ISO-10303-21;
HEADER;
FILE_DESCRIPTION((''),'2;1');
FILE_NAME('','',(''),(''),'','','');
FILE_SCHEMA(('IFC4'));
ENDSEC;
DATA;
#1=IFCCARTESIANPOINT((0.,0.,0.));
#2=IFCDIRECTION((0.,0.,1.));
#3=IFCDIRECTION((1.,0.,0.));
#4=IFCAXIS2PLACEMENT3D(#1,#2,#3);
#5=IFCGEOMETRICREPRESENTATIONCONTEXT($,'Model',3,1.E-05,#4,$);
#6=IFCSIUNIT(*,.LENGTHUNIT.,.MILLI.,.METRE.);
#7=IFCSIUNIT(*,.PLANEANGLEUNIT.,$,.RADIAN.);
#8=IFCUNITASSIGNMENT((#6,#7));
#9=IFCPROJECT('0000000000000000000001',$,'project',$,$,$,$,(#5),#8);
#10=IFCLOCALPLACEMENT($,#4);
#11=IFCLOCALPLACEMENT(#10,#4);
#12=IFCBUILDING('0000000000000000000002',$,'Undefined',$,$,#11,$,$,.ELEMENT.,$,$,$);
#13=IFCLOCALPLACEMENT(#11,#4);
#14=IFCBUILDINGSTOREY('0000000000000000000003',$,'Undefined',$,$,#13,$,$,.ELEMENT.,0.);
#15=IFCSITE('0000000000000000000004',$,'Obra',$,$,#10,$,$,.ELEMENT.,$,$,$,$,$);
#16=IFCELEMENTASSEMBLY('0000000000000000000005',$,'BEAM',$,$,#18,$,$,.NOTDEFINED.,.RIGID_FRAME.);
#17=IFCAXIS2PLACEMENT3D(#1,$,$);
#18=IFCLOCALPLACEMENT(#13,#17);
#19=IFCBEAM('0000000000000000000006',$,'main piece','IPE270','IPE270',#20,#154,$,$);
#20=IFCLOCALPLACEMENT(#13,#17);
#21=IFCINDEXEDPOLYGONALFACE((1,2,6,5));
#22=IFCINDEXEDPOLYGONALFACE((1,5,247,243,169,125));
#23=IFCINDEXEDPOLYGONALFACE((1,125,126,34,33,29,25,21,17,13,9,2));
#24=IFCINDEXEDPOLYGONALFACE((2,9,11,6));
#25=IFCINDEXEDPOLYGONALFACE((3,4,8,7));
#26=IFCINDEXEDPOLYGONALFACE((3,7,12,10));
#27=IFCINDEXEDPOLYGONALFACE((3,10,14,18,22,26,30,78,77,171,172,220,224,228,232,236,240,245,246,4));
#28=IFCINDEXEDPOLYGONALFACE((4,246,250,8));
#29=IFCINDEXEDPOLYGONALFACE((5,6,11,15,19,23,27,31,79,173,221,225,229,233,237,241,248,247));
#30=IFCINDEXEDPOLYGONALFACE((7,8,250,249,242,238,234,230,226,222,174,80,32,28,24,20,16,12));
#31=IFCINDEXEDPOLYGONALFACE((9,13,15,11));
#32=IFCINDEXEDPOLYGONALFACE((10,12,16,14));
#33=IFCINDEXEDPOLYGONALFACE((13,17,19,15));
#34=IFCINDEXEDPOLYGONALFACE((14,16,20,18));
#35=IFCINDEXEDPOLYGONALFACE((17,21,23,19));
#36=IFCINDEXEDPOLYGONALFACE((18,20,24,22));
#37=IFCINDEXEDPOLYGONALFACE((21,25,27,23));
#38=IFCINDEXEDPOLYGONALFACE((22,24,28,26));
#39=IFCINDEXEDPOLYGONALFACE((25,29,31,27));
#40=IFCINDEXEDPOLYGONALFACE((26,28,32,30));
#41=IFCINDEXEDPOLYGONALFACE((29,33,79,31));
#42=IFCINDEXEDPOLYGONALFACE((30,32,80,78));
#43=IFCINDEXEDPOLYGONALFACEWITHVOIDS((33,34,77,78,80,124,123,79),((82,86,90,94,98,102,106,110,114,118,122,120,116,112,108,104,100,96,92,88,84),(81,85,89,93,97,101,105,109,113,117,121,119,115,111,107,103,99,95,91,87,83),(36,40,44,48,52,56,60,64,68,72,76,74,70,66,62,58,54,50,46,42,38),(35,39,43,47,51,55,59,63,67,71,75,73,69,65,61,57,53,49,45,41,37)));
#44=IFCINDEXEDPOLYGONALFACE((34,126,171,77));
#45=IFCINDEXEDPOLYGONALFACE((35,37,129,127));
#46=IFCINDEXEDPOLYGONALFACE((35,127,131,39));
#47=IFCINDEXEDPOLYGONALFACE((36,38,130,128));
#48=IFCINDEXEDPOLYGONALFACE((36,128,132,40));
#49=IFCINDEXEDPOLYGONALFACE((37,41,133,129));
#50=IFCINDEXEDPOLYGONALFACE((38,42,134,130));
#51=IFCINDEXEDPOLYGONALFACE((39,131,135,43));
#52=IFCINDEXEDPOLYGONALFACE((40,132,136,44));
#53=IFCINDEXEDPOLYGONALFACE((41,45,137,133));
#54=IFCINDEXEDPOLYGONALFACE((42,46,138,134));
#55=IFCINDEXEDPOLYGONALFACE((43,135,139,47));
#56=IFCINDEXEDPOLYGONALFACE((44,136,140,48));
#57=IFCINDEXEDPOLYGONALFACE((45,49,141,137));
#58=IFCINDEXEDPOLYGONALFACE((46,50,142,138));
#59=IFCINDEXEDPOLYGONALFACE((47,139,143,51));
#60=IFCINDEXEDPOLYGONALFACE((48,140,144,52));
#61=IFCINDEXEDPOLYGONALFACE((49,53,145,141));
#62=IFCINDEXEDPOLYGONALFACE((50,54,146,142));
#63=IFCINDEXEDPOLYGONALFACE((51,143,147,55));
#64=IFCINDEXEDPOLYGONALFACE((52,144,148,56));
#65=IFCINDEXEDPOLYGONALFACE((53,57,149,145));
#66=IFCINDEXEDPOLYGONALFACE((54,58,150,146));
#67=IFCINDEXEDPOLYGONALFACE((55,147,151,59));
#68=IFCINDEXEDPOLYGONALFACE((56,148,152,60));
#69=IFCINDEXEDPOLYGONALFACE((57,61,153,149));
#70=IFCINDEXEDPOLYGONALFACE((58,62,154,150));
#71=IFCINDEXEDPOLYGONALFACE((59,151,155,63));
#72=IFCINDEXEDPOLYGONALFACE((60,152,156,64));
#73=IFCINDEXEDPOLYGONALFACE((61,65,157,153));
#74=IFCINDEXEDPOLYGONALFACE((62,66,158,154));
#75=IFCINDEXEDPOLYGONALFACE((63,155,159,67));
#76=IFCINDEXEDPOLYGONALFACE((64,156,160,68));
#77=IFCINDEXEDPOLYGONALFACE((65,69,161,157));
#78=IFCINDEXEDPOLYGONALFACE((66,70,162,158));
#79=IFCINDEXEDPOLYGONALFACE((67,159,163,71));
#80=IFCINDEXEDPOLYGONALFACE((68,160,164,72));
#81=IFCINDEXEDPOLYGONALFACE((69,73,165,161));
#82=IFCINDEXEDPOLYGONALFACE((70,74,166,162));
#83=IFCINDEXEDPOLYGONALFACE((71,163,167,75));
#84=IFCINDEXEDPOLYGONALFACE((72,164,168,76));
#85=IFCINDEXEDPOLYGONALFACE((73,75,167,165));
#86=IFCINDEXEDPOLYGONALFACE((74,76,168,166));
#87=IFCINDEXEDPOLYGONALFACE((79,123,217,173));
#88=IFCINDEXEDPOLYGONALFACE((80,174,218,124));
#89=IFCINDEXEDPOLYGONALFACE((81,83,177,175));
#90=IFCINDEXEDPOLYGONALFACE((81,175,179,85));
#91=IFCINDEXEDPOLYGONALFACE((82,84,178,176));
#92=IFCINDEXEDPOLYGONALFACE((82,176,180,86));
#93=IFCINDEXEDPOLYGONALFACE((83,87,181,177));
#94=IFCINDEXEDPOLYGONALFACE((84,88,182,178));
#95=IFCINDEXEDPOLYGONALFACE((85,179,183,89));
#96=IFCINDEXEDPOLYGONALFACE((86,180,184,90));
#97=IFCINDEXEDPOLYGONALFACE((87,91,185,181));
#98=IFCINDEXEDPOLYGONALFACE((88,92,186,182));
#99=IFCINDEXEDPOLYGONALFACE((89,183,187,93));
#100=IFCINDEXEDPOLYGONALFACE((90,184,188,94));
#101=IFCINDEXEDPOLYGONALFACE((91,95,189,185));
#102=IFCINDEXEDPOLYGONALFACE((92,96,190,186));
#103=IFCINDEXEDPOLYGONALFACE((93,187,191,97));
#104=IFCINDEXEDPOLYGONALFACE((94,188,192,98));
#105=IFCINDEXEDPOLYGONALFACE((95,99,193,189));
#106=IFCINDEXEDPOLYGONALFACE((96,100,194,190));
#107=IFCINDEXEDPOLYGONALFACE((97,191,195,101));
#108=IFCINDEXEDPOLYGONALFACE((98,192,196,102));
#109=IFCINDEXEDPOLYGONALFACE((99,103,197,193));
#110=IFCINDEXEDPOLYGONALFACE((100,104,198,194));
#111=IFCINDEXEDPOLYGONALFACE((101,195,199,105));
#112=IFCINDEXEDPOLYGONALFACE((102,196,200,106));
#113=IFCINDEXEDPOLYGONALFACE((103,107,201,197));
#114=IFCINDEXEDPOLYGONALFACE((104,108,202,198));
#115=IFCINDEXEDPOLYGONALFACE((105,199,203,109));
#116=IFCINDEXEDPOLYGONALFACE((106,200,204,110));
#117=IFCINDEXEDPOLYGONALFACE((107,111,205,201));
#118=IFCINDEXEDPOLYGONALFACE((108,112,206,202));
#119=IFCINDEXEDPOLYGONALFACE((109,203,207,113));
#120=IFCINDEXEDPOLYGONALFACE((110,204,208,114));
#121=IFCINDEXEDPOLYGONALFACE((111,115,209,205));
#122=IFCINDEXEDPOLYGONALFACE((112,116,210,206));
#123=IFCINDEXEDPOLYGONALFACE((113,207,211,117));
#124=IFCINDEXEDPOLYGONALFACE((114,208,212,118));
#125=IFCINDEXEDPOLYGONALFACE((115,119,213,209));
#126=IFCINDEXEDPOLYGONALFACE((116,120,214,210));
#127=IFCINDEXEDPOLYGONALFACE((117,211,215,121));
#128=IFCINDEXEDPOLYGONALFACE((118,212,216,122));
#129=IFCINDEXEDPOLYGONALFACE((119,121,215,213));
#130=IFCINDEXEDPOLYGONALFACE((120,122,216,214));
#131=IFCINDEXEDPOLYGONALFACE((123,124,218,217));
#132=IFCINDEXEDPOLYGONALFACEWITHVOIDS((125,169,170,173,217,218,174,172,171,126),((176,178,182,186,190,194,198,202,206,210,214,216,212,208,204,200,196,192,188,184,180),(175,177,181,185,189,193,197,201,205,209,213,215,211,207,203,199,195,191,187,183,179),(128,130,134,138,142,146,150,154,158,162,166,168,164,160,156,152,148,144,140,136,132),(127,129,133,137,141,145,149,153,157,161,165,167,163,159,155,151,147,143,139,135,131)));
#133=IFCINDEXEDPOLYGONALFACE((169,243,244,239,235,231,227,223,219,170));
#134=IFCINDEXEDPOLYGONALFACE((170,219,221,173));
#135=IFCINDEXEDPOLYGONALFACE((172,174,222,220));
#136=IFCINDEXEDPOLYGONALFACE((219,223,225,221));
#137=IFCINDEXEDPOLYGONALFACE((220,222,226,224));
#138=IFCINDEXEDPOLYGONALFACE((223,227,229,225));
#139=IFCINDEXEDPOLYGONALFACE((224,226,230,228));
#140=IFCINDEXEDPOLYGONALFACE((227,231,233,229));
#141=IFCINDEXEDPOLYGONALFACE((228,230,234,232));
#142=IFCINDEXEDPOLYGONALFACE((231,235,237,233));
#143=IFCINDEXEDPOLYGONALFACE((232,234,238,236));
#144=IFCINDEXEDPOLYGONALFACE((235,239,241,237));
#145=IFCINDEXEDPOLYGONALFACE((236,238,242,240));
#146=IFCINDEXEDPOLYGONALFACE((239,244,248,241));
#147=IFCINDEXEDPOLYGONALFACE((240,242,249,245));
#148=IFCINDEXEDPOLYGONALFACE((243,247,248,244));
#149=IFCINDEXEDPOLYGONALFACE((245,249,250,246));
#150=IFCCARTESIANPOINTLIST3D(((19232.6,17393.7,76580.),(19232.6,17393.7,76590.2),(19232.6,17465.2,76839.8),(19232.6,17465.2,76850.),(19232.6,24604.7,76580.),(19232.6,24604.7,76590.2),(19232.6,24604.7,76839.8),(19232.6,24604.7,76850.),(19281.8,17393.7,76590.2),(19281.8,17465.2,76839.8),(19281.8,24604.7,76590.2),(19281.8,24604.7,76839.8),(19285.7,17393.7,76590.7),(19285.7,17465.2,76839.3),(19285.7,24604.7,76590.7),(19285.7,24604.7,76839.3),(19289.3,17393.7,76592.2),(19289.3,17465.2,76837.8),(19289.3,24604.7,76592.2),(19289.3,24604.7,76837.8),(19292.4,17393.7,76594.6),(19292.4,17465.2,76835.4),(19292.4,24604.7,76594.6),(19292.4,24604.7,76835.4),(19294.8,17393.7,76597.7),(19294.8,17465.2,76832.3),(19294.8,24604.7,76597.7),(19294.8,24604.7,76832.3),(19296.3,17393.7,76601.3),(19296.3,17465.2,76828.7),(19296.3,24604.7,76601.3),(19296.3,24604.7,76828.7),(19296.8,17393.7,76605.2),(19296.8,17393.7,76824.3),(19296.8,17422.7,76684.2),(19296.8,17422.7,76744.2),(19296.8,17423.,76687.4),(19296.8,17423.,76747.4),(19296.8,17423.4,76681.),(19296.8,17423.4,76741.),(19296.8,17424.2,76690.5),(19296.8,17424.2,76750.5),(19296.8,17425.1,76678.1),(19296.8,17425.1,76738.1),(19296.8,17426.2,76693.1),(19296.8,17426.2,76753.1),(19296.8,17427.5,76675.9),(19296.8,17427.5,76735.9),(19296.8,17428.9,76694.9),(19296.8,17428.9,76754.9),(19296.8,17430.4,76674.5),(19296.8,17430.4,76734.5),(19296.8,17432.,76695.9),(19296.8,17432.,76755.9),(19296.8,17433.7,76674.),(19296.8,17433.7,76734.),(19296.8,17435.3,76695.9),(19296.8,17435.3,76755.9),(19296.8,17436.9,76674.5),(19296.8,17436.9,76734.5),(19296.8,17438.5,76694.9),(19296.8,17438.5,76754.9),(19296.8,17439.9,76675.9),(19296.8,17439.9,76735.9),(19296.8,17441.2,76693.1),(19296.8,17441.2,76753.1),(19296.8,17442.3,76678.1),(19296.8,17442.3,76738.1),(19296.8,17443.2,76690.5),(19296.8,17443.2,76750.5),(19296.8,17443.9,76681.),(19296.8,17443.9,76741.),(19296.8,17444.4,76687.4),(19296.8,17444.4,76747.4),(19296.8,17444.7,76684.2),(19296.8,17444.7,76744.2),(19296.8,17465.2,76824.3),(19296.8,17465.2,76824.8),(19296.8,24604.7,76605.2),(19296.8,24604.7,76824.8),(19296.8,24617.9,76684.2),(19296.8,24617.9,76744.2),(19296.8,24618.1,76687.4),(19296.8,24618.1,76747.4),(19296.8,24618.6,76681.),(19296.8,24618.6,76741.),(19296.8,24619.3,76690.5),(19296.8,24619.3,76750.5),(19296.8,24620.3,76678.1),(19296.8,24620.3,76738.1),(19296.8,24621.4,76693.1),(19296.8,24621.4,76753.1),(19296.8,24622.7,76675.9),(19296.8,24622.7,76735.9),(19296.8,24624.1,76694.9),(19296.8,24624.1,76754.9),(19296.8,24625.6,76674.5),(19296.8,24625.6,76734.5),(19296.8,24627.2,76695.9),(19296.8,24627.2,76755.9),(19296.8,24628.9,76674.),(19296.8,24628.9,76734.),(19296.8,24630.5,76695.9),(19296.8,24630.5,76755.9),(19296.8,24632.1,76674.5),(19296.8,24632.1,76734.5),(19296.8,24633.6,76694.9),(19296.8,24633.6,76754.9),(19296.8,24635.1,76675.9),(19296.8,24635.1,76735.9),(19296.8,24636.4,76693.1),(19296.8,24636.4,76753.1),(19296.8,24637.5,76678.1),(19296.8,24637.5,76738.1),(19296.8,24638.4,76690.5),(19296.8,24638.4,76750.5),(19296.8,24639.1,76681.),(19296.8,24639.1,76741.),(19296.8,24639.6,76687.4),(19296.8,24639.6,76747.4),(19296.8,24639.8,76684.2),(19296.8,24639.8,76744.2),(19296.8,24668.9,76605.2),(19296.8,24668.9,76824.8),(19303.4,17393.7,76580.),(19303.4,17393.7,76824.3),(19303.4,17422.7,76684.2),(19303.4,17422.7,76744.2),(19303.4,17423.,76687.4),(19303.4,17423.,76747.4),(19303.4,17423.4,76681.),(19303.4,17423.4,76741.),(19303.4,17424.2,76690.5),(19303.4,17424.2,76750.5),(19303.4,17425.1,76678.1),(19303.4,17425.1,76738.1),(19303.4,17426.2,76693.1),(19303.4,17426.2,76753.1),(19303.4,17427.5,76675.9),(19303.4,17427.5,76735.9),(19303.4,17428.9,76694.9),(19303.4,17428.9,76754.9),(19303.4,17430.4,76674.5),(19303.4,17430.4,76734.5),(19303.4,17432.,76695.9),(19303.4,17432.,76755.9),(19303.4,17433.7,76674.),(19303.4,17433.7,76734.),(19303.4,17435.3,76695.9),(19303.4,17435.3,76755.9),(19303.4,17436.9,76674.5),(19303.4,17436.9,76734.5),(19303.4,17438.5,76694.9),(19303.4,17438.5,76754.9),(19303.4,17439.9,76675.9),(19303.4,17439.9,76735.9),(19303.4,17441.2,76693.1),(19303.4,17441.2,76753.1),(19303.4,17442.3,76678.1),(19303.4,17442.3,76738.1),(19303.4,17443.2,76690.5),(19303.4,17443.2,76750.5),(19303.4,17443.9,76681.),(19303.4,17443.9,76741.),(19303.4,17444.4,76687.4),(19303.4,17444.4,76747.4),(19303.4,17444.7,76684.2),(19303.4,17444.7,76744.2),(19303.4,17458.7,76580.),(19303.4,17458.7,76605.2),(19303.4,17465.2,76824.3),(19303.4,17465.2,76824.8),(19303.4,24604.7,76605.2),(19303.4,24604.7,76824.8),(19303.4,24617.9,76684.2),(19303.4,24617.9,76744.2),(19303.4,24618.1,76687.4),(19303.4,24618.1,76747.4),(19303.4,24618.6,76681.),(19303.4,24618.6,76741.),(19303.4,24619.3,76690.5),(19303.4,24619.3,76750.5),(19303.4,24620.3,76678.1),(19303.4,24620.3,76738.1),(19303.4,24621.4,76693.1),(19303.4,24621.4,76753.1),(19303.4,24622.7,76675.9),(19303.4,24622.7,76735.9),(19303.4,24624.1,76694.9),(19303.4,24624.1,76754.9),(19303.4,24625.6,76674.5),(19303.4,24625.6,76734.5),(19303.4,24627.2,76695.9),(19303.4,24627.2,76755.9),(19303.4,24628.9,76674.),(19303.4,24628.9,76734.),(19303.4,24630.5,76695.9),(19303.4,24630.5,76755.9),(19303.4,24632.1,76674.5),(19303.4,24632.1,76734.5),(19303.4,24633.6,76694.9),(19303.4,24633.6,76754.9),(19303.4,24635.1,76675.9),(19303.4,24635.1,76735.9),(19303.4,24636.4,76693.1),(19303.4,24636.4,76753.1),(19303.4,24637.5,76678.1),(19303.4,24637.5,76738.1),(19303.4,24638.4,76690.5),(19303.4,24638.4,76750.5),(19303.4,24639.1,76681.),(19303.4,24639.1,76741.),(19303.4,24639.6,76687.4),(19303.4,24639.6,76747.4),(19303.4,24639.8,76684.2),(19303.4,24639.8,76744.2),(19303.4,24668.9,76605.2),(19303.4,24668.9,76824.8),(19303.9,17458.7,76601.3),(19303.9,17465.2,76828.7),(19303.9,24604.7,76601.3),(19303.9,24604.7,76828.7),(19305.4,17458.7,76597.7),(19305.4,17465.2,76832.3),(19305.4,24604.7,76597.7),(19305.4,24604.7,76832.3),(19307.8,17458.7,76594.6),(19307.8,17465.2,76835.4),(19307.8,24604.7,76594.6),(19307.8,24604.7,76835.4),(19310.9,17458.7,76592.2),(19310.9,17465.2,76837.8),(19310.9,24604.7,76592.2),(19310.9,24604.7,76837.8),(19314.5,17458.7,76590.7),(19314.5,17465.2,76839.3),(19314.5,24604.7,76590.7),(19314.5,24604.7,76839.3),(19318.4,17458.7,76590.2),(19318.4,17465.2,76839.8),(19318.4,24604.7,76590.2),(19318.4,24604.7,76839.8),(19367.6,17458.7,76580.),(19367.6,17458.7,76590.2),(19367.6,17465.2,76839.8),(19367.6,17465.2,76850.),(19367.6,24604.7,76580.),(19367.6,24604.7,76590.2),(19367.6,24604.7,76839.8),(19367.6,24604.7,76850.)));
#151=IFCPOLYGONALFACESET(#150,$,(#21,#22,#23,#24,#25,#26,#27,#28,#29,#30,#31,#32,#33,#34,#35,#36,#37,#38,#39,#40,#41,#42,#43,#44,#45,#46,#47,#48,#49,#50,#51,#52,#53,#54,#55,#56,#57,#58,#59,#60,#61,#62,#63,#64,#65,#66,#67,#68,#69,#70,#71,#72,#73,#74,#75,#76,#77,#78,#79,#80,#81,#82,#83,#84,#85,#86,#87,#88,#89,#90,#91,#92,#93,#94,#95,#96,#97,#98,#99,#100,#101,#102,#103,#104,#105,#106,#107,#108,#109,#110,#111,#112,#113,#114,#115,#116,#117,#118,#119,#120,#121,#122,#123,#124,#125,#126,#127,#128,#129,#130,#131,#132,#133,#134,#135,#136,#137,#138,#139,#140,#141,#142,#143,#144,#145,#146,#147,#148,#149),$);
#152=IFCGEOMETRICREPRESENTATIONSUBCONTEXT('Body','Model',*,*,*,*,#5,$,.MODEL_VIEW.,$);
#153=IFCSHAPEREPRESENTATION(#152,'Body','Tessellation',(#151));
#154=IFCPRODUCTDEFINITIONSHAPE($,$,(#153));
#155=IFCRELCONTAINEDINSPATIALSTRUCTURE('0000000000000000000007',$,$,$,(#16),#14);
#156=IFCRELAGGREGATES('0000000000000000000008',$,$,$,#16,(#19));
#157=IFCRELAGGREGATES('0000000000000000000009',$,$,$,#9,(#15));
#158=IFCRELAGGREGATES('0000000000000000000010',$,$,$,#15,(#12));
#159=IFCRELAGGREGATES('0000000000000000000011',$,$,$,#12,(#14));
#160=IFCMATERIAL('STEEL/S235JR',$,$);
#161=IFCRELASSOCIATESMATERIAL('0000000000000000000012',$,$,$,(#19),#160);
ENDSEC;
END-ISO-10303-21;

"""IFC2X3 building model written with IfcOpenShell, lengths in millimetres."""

from ifc_helpers import new_model, si_unit, frame, origin_with_axes, origin_2d_with_axis, place, context, subcontext, project, spatial, rectangle, circle, i_section, extrude, clip, halfspace, source, transform, mapped, material, element, aggregate, save


model = new_model("IFC2X3")

# Units and contexts
model_context = context("Model", 3, precision=1e-05, world=origin_with_axes())
body_context = subcontext(model_context, "Body", "Model", "MODEL_VIEW")
ifc_project = project(units=[si_unit("LENGTHUNIT", "METRE", prefix="MILLI"), si_unit("PLANEANGLEUNIT", "RADIAN")], contexts=[model_context])

# Site, building, storey
site_placement = place(None, origin_with_axes())
site = spatial("IfcSite", under=ifc_project, at=site_placement, Name="Obra", CompositionType="ELEMENT")
building_placement = place(site_placement, origin_with_axes())
building = spatial("IfcBuilding", under=site, at=building_placement, Name="Undefined", CompositionType="ELEMENT")
storey_placement = place(building_placement, origin_with_axes())
storey = spatial("IfcBuildingStorey", under=building, at=storey_placement, Name="Undefined", CompositionType="ELEMENT", Elevation=0.0)

# Shared definitions
ifc_material = material(Name="STEEL/S235JR")

# Element assembly, beam, openings
assembly_1_placement = place(storey_placement, origin_with_axes())
assembly_1 = element("IfcElementAssembly", 1, at=assembly_1_placement, inside=storey, Name="BEAM", AssemblyPlace="NOTDEFINED", PredefinedType="RIGID_FRAME")
beam_1_placement = place(assembly_1_placement, frame((19300.1, 17475.1, 76715.0), z_axis=(0.0, 0.0, 1.0), x_axis=(0.0, 1.0, 0.0)))
beam_1 = element("IfcBeam", 2, at=beam_1_placement, material=ifc_material, Name="main piece", Description="IPE270", ObjectType="IPE270", context=body_context, shape_type="Clipping", body=[
    clip(clip(extrude(i_section(OverallWidth=135.0, OverallDepth=270.0, WebThickness=6.6, FlangeThickness=10.2, FilletRadius=15.0, at=origin_2d_with_axis()), frame((7193.7, 0.0, 0.0), z_axis=(-1.0, 0.0, 0.0), x_axis=(0.0, -1.0, 0.0)), (0.0, 0.0, 1.0), 7275.2), halfspace(frame((7193.7, 0.0, -235.0), z_axis=(-1.0, -0.000002, 0.0), x_axis=(-0.000002, 1.0, 0.0)), True)), halfspace(frame((-81.4, 0.0, -235.0), z_axis=(1.0, 0.0, 0.0), x_axis=(0.0, -1.0, 0.0)), True)),
])
opening_1_placement = place(assembly_1_placement, frame((19300.1, 17475.1, 76715.0), z_axis=(0.0, 0.0, 1.0), x_axis=(0.0, 1.0, 0.0)))
element("IfcOpeningElement", 3, at=opening_1_placement, cuts=beam_1, ObjectType="Recess", context=body_context, shape_type="SweptSolid", body=[
    extrude(rectangle(XDim=26.2, YDim=76.2, at=origin_2d_with_axis()), frame((7167.6, 68.5, -122.9), z_axis=(0.000002, -1.0, 0.0), x_axis=(0.0, 0.0, -1.0)), (0.0, 0.0, 1.0), 137.0),
])
opening_2_placement = place(assembly_1_placement, frame((19300.1, 17475.1, 76715.0), z_axis=(0.0, 0.0, 1.0), x_axis=(0.0, 1.0, 0.0)))
element("IfcOpeningElement", 4, at=opening_2_placement, cuts=beam_1, ObjectType="Recess", context=body_context, shape_type="SweptSolid", body=[
    extrude(rectangle(XDim=26.2, YDim=76.2, at=origin_2d_with_axis()), frame((7167.6, 68.5, 122.9), z_axis=(0.000002, -1.0, 0.0), x_axis=(0.0, 0.0, -1.0)), (0.0, 0.0, 1.0), 137.0),
])
opening_3_placement = place(assembly_1_placement, frame((19300.1, 17475.1, 76715.0), z_axis=(0.0, 0.0, 1.0), x_axis=(0.0, 1.0, 0.0)))
element("IfcOpeningElement", 5, at=opening_3_placement, cuts=beam_1, ObjectType="Recess", context=body_context, shape_type="SweptSolid", body=[
    extrude(rectangle(XDim=75.0, YDim=300.0, at=origin_2d_with_axis()), frame((-53.9, -153.3, 124.3), z_axis=(0.0, 0.0, -1.0), x_axis=(1.0, 0.0, 0.0)), (0.0, 0.0, 1.0), 278.6),
])
opening_4_placement = place(assembly_1_placement, frame((19300.1, 17475.1, 76715.0), z_axis=(0.0, 0.0, 1.0), x_axis=(0.0, 1.0, 0.0)))
element("IfcOpeningElement", 6, at=opening_4_placement, cuts=beam_1, ObjectType="Recess", context=body_context, shape_type="SweptSolid", body=[
    extrude(rectangle(XDim=26.7, YDim=83.5, at=origin_2d_with_axis()), frame((-51.7, -68.5, 122.7), z_axis=(0.0, 1.0, 0.0), x_axis=(0.0, 0.0, -1.0)), (0.0, 0.0, 1.0), 137.0),
])
shared_shape_1 = source(origin_with_axes(), body_context, "Body", "SweptSolid", [
    extrude(circle(Radius=11.0, at=origin_2d_with_axis()), frame((0.0, -3.4, 0.0), z_axis=(0.0, 1.0, 0.0), x_axis=(1.0, 0.0, 0.0)), (0.0, 0.0, 1.0), 6.8),
])
opening_5_placement = place(assembly_1_placement, frame((19300.1, 24668.9, 76850.0), z_axis=(0.000002, -1.0, 0.0), x_axis=(0.0, 0.0, -1.0)))
element("IfcOpeningElement", 7, at=opening_5_placement, cuts=beam_1, ObjectType="Opening", context=body_context, shape_type="MappedRepresentation", body=[
    mapped(shared_shape_1, transform((105.0, 0.0, 40.0))),
    mapped(shared_shape_1, transform((165.0, 0.0, 40.0))),
])
opening_6_placement = place(assembly_1_placement, frame((19300.1, 17393.7, 76850.0), z_axis=(0.0, 1.0, 0.0), x_axis=(0.0, 0.0, -1.0)))
element("IfcOpeningElement", 8, at=opening_6_placement, cuts=beam_1, ObjectType="Opening", context=body_context, shape_type="MappedRepresentation", body=[
    mapped(shared_shape_1, transform((105.0, 0.0, 40.0))),
    mapped(shared_shape_1, transform((165.0, 0.0, 40.0))),
])
aggregate(assembly_1, [beam_1])

save(model, "model.ifc")
